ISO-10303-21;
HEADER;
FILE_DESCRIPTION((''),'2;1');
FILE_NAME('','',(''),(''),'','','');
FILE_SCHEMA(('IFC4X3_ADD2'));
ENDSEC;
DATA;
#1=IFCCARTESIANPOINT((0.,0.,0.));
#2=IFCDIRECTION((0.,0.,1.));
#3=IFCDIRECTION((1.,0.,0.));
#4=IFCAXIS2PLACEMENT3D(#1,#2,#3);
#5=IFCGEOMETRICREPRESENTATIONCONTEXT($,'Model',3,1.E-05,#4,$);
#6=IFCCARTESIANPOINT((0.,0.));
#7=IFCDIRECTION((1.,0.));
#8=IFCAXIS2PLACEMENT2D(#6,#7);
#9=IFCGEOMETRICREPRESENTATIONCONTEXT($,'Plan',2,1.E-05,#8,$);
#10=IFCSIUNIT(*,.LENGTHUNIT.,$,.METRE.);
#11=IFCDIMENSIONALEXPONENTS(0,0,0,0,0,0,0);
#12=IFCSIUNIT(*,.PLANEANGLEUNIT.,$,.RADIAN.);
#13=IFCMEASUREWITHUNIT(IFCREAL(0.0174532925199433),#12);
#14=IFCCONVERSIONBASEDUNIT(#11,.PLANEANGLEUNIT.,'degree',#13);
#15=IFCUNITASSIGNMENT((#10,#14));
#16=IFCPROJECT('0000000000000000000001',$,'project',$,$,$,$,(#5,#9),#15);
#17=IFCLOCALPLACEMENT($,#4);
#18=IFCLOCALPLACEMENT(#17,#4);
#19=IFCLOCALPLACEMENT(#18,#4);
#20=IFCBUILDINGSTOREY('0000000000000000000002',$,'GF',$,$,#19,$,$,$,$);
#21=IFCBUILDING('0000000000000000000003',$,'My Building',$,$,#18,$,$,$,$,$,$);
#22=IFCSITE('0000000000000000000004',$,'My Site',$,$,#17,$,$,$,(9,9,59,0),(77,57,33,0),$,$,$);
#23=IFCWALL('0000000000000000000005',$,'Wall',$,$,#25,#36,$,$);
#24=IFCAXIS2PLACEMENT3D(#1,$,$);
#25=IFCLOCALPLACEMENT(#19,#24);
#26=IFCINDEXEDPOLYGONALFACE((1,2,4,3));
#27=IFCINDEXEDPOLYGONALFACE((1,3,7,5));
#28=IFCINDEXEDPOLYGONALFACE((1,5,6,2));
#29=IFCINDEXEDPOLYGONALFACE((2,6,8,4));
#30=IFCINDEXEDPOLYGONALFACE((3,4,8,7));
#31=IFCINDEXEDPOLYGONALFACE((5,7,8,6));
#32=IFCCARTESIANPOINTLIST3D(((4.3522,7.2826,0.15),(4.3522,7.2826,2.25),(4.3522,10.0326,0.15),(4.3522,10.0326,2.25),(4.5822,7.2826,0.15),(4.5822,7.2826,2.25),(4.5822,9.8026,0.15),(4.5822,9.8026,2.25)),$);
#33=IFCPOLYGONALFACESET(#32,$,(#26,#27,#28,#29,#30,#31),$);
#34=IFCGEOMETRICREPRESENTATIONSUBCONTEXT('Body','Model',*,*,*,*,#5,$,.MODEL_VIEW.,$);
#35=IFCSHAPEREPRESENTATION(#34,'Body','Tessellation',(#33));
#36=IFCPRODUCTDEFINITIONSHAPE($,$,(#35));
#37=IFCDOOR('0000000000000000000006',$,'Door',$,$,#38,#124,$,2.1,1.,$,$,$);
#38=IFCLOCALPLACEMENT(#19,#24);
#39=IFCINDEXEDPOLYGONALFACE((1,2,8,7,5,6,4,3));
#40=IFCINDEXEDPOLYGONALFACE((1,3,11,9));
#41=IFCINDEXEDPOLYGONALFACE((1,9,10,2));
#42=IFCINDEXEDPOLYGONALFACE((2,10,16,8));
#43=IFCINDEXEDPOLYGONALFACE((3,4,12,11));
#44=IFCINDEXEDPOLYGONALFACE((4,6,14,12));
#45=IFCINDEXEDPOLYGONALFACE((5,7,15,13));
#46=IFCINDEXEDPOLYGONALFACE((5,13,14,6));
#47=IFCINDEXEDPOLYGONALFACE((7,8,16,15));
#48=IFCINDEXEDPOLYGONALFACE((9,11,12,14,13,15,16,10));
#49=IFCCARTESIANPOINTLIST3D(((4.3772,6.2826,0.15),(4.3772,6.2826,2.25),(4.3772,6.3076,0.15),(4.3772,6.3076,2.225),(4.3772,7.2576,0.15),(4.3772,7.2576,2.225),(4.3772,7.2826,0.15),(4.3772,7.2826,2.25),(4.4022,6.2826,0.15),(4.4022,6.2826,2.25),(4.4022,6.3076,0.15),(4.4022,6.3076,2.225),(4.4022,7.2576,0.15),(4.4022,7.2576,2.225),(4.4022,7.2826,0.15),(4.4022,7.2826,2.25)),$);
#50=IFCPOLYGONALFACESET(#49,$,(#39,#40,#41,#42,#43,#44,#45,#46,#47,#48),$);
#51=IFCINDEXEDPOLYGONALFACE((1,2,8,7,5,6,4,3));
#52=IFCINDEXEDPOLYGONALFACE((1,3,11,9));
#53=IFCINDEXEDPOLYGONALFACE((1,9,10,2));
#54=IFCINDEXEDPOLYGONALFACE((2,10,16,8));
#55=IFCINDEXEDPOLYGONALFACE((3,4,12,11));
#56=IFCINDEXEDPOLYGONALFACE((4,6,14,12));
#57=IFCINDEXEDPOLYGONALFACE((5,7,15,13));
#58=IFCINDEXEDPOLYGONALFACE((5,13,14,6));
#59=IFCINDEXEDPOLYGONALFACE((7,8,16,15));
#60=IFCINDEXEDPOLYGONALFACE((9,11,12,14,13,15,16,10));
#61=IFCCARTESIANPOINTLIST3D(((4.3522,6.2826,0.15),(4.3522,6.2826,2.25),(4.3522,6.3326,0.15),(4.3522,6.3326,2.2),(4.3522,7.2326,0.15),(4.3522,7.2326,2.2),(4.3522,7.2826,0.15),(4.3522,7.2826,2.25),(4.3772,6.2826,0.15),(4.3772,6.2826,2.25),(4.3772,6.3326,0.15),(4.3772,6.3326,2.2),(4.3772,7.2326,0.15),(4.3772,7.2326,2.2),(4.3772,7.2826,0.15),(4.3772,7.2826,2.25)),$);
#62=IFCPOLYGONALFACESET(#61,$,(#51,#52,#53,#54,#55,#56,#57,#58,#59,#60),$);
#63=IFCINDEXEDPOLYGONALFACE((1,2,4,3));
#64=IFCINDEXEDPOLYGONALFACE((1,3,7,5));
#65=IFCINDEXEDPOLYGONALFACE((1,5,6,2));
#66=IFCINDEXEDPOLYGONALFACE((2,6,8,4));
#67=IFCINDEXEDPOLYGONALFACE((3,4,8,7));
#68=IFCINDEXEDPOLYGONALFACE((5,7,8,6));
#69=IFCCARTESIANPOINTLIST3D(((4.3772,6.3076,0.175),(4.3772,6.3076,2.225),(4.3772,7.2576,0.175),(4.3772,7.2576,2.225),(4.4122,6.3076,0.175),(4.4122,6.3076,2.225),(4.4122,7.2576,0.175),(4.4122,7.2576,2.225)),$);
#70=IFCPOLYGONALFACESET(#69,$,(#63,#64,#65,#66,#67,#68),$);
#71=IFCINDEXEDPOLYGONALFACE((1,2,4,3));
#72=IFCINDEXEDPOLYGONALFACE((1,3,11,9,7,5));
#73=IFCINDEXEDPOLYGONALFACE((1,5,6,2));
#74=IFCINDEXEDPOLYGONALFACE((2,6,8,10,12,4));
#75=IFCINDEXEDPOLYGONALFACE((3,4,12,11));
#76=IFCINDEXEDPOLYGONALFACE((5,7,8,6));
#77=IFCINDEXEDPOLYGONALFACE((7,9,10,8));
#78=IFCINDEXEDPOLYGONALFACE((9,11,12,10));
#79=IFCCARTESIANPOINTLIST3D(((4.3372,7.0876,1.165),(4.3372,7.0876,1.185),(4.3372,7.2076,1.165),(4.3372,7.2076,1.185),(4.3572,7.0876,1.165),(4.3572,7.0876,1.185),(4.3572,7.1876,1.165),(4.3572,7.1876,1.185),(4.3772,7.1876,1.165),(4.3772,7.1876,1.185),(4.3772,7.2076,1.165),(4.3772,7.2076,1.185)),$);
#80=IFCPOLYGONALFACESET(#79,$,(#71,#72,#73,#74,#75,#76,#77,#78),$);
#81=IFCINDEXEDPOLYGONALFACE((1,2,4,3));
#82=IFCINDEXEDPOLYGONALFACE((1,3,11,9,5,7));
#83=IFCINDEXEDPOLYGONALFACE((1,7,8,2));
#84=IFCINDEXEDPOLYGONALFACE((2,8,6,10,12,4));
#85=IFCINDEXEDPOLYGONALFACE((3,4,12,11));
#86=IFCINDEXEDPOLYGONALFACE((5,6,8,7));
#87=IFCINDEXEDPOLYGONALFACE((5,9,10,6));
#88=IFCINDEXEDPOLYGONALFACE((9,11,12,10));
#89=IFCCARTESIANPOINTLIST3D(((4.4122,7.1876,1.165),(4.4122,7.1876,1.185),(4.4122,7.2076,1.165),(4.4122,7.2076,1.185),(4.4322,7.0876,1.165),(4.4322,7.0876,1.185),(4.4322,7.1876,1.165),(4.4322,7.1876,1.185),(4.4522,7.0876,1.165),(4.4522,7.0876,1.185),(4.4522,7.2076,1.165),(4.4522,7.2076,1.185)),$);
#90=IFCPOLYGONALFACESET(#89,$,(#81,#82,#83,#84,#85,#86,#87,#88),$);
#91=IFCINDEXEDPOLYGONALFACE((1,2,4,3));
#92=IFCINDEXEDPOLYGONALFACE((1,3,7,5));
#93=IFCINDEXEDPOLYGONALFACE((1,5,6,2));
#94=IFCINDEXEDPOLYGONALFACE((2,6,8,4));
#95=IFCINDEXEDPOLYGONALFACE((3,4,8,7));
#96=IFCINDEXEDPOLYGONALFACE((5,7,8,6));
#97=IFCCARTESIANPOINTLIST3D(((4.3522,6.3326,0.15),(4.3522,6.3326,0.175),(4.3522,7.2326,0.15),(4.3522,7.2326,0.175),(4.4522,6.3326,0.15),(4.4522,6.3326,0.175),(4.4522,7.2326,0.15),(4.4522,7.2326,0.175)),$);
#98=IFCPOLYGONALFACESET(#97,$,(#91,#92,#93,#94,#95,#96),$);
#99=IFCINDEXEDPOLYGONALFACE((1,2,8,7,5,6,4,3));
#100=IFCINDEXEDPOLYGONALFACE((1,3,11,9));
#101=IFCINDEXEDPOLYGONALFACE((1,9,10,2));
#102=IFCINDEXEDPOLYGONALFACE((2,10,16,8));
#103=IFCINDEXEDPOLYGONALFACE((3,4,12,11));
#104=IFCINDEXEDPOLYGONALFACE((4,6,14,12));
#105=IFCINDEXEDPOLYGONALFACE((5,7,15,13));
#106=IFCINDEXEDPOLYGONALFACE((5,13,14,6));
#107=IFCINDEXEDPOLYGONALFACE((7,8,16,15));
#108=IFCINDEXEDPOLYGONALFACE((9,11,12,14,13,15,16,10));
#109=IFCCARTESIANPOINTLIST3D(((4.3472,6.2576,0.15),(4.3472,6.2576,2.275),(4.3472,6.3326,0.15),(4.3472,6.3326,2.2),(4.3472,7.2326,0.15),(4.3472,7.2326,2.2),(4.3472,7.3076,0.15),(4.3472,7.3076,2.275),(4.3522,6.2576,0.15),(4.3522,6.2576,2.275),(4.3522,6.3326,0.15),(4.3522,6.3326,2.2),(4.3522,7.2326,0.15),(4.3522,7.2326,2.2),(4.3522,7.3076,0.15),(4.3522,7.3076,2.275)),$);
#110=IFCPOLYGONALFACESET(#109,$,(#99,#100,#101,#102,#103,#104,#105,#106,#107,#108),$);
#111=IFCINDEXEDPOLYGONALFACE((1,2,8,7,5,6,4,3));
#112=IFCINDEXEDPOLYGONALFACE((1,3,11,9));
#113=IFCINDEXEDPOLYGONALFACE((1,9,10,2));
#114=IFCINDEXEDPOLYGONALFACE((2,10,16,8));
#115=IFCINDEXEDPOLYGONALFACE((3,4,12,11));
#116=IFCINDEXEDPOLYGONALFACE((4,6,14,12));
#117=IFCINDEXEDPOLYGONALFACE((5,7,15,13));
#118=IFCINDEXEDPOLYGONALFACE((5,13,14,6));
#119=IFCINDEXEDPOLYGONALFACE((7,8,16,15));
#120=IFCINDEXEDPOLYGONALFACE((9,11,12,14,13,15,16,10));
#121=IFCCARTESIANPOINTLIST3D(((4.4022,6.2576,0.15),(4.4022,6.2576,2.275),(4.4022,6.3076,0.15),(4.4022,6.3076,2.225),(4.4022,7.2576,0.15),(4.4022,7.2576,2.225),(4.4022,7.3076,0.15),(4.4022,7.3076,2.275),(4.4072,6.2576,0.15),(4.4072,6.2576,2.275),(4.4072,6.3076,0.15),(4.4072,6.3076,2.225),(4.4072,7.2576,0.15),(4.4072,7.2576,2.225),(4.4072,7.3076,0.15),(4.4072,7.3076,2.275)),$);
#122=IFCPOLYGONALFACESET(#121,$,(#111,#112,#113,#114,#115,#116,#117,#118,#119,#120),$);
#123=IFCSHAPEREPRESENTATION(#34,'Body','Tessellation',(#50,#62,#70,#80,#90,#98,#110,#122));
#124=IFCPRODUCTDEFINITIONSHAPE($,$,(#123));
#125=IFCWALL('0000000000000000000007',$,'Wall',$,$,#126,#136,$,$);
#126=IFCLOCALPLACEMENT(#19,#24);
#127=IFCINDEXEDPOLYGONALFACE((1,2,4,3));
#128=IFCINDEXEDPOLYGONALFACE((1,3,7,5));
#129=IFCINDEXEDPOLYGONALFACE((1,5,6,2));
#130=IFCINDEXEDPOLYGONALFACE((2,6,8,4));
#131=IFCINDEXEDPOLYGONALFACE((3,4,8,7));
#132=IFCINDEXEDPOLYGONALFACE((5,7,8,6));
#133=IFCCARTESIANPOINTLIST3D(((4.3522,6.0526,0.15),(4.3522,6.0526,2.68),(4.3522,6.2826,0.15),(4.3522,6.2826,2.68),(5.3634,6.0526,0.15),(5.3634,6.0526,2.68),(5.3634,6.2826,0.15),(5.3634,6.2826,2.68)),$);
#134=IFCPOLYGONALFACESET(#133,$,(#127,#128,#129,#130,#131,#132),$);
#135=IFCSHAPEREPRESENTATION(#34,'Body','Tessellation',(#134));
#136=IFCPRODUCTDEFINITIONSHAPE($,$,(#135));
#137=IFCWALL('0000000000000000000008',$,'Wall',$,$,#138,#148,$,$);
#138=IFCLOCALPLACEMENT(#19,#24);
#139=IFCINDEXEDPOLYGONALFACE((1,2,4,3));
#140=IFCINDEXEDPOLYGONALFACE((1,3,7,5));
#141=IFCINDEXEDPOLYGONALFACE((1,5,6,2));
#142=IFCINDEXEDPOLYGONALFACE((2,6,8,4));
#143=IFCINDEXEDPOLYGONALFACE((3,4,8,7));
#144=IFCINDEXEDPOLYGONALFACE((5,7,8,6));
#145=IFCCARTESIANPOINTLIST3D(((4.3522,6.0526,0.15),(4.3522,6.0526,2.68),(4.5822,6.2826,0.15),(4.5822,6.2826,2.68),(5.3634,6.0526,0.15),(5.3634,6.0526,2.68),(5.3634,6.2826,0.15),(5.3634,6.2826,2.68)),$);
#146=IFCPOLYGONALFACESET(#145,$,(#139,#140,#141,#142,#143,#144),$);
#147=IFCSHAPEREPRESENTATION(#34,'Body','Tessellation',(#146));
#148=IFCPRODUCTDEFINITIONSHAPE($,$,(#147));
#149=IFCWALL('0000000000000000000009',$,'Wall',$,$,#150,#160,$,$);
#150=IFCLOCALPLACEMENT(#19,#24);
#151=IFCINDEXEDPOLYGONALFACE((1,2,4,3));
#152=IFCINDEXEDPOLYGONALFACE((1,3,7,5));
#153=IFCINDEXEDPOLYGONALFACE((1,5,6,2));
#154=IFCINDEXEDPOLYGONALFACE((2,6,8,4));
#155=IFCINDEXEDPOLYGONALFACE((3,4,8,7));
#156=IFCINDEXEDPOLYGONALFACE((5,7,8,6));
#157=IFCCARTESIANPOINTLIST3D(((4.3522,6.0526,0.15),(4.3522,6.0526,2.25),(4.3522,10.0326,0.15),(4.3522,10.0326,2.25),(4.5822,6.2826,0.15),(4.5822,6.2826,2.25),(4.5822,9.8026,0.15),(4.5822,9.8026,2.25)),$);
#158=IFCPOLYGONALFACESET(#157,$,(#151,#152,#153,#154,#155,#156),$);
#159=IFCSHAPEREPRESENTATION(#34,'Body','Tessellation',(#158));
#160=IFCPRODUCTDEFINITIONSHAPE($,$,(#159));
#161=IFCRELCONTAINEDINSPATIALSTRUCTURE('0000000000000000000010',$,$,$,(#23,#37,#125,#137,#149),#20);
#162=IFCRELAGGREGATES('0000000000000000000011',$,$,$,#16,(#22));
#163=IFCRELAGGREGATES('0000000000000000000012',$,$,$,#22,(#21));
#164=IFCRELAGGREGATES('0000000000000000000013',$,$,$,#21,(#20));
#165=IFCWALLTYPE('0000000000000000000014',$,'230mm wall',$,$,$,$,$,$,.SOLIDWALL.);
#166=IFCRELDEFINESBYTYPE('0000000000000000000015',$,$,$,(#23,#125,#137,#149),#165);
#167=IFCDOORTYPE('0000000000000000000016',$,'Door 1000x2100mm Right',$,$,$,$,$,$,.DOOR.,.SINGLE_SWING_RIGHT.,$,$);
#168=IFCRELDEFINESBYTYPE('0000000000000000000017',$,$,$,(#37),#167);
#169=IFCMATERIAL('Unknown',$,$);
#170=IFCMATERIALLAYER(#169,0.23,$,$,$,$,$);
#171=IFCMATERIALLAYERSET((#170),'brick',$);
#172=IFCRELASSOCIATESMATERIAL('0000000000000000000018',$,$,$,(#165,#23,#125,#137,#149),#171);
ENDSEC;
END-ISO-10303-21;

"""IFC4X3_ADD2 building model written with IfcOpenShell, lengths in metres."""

from ifc_helpers import new_model, entity, si_unit, converted_unit, frame, origin_with_axes, origin_2d_with_axis, place, context, subcontext, project, spatial, line, indexed_curve, outline, extrude, shape, source, transform, mapped, material, layer, layer_set, layer_usage, type_object, type_shapes, element, fill, save


model = new_model("IFC4X3_ADD2")

# Units and contexts
model_context = context("Model", 3, precision=1e-05, world=origin_with_axes())
plan_context = context("Plan", 2, precision=1e-05, world=origin_2d_with_axis())
body_context_1 = subcontext(model_context, "Body", "Model", "MODEL_VIEW")
body_context_2 = subcontext(plan_context, "Body", "Plan", "PLAN_VIEW")
ifc_project = project(units=[si_unit("LENGTHUNIT", "METRE"), converted_unit("PLANEANGLEUNIT", "degree", entity("IfcReal", 0.0174532925199433), si_unit("PLANEANGLEUNIT", "RADIAN"), dimensions=[0, 0, 0, 0, 0, 0, 0])], contexts=[model_context, plan_context])

# Site, building, storey
site_placement = place(None, origin_with_axes())
site = spatial("IfcSite", under=ifc_project, at=site_placement, Name="My Site", RefLatitude=(9, 9, 59, 0), RefLongitude=(77, 57, 33, 0))
building_placement = place(site_placement, origin_with_axes())
building = spatial("IfcBuilding", under=site, at=building_placement, Name="My Building")
storey_placement = place(building_placement, origin_with_axes())
storey = spatial("IfcBuildingStorey", under=building, at=storey_placement, Name="GF")

# Shared definitions
ifc_material_1 = material(Name="Unknown")
ifc_layer_1 = layer(ifc_material_1, 0.23)
ifc_layer_set_1 = layer_set([ifc_layer_1], Name="brick")
wall_type_1 = type_object("IfcWallType", Name="230mm wall", PredefinedType="SOLIDWALL", material=ifc_layer_set_1)

# Wall, opening, door
ifc_layer_usage_1 = layer_usage(ifc_layer_set_1, "AXIS2", "POSITIVE", 0.0)
wall_1_placement = place(storey_placement, frame((4.5822, 6.2826, 0.15), z_axis=(0.0, 0.0, 1.0), x_axis=(0.0, 1.0, 0.0)))
wall_1 = element("IfcWall", 1, at=wall_1_placement, inside=storey, type_object=wall_type_1, material=ifc_layer_usage_1, Name="Wall", context=body_context_1, shape_type="SweptSolid", body=[
    extrude(outline(indexed_curve([(0.0, 0.0), (0.0, 0.23), (3.75, 0.23), (3.52, 0.0)], segments=[line(1, 2, 3, 4, 1)])), origin_with_axes(), (0.0, 0.0, 1.0), 2.1),
])
shared_shape_1 = source(origin_with_axes(), body_context_1, "Body", "SweptSolid", [
    extrude(outline(indexed_curve([(0.0, 0.0), (1.0, 0.0), (1.0, 2.1), (0.0, 2.1)], segments=[line(1, 2, 3, 4, 1)])), frame((0.0, -0.6, 0.0), z_axis=(0.0, -1.0, 0.0), x_axis=(1.0, 0.0, 0.0)), (0.0, 0.0, -1.0), 1.2),
])
opening_1_placement = place(wall_1_placement, frame((1.0, 0.23, 0.0), z_axis=(0.0, 0.0, 1.0), x_axis=(-1.0, 0.0, 0.0)))
opening_1 = element("IfcOpeningElement", 2, at=opening_1_placement, cuts=wall_1, PredefinedType="OPENING", context=body_context_1, shape_type="MappedRepresentation", body=[
    mapped(shared_shape_1, transform((0.0, 0.0, 0.0), x_axis=(1.0, 0.0, 0.0), y_axis=(0.0, 1.0, 0.0), z_axis=(0.0, 0.0, 1.0), scale=1.0)),
])
door_type_1 = type_object("IfcDoorType", Name="Door 1000x2100mm Right", OperationType="SINGLE_SWING_RIGHT", PredefinedType="DOOR")
shared_shape_2 = source(origin_with_axes(), body_context_1, "Body", "SweptSolid", [
    extrude(outline(indexed_curve([(0.0, 0.0), (0.0, 2.1), (1.0, 2.1), (1.0, 0.0), (0.975, 0.0), (0.975, 2.075), (0.025, 2.075), (0.025, 0.0)], segments=[line(1, 2, 3, 4, 5, 6, 7, 8, 1)])), frame((0.0, 0.025, 0.0), z_axis=(0.0, -1.0, 0.0), x_axis=(1.0, 0.0, 0.0)), (0.0, 0.0, -1.0), 0.025),
    extrude(outline(indexed_curve([(0.0, 0.0), (0.0, 2.1), (1.0, 2.1), (1.0, 0.0), (0.95, 0.0), (0.95, 2.05), (0.05, 2.05), (0.05, 0.0)], segments=[line(1, 2, 3, 4, 5, 6, 7, 8, 1)])), frame((0.0, 0.0, 0.0), z_axis=(0.0, -1.0, 0.0), x_axis=(1.0, 0.0, 0.0)), (0.0, 0.0, -1.0), 0.025),
    extrude(outline(indexed_curve([(0.0, 0.0), (0.95, 0.0), (0.95, 0.035), (0.0, 0.035)], segments=[line(1, 2, 3, 4, 1)])), frame((0.025, 0.025, 0.025), z_axis=(0.0, 0.0, 1.0), x_axis=(1.0, 0.0, 0.0)), (0.0, 0.0, 1.0), 2.05),
    extrude(outline(indexed_curve([(0.0, 0.0), (0.0, -0.04), (0.12, -0.04), (0.12, -0.02), (0.02, -0.02), (0.02, 0.0)], segments=[line(1, 2, 3, 4, 5, 6, 1)])), frame((0.075, 0.025, 1.015), z_axis=(0.0, 0.0, 1.0), x_axis=(1.0, 0.0, 0.0)), (0.0, 0.0, 1.0), 0.02),
    extrude(outline(indexed_curve([(0.0, 0.0), (0.0, 0.04), (0.12, 0.04), (0.12, 0.02), (0.02, 0.02), (0.02, 0.0)], segments=[line(1, 2, 3, 4, 5, 6, 1)])), frame((0.075, 0.06, 1.015), z_axis=(0.0, 0.0, 1.0), x_axis=(1.0, 0.0, 0.0)), (0.0, 0.0, 1.0), 0.02),
    extrude(outline(indexed_curve([(0.0, 0.0), (0.9, 0.0), (0.9, 0.1), (0.0, 0.1)], segments=[line(1, 2, 3, 4, 1)])), frame((0.05, 0.0, 0.0), z_axis=(0.0, 0.0, 1.0), x_axis=(1.0, 0.0, 0.0)), (0.0, 0.0, 1.0), 0.025),
    extrude(outline(indexed_curve([(0.0, 0.0), (0.0, 2.125), (1.05, 2.125), (1.05, 0.0), (0.975, 0.0), (0.975, 2.05), (0.075, 2.05), (0.075, 0.0)], segments=[line(1, 2, 3, 4, 5, 6, 7, 8, 1)])), frame((-0.025, -0.005, 0.0), z_axis=(0.0, -1.0, 0.0), x_axis=(1.0, 0.0, 0.0)), (0.0, 0.0, -1.0), 0.005),
    extrude(outline(indexed_curve([(0.0, 0.0), (0.0, 2.125), (1.05, 2.125), (1.05, 0.0), (1.0, 0.0), (1.0, 2.075), (0.05, 2.075), (0.05, 0.0)], segments=[line(1, 2, 3, 4, 5, 6, 7, 8, 1)])), frame((-0.025, 0.05, 0.0), z_axis=(0.0, -1.0, 0.0), x_axis=(1.0, 0.0, 0.0)), (0.0, 0.0, -1.0), 0.005),
])
shared_shape_3 = source(origin_with_axes(), body_context_2, "Body", "Curve2D", [
    entity("IfcIndexedPolyCurve", entity("IfcCartesianPointList2D", [[0.0, 0.0], [0.0, 0.05], [0.025, 0.05], [0.025, 0.025], [0.05, 0.025], [0.05, 0.0]]), [entity("IfcLineIndex", [1, 2, 3, 4, 5, 6, 1])]),
    entity("IfcIndexedPolyCurve", entity("IfcCartesianPointList2D", [[1.0, 0.0], [1.0, 0.05], [0.975, 0.05], [0.975, 0.025], [0.95, 0.025], [0.95, 0.0]]), [entity("IfcLineIndex", [1, 2, 3, 4, 5, 6, 1])]),
    entity("IfcTrimmedCurve", entity("IfcEllipse", entity("IfcAxis2Placement2D", entity("IfcCartesianPoint", [0.94, 0.05]), entity("IfcDirection", [1.0, 0.0])), 0.915, 0.95), [entity("IfcCartesianPoint", [0.94, 1.0])], [entity("IfcCartesianPoint", [0.025, 0.05])], True, "CARTESIAN"),
    entity("IfcIndexedPolyCurve", entity("IfcCartesianPointList2D", [[0.975, 0.05], [0.94, 0.05], [0.94, 1.0], [0.975, 1.0]]), [entity("IfcLineIndex", [1, 2, 3, 4, 1])]),
])
type_shapes(door_type_1, [shared_shape_2, shared_shape_3])
door_1_placement = place(opening_1_placement, frame((0.0, 0.0, 0.0), z_axis=(0.0, 0.0, 1.0), x_axis=(1.0, 0.0, 0.0)))
door_1 = element("IfcDoor", 3, at=door_1_placement, inside=storey, type_object=door_type_1, Name="Door", OverallHeight=2.1, OverallWidth=1.0, shapes=[
    shape(body_context_1, "Body", "MappedRepresentation", [mapped(shared_shape_2, transform((0.0, 0.0, 0.0), x_axis=(1.0, 0.0, 0.0), y_axis=(0.0, 1.0, 0.0), z_axis=(0.0, 0.0, 1.0), scale=1.0))]),
    shape(body_context_2, "Body", "MappedRepresentation", [mapped(shared_shape_3, transform((0.0, 0.0, 0.0), x_axis=(1.0, 0.0, 0.0), y_axis=(0.0, 1.0, 0.0), z_axis=(0.0, 0.0, 1.0), scale=1.0))]),
])
fill(opening_1, door_1)

# Walls
ifc_layer_usage_2 = layer_usage(ifc_layer_set_1, "AXIS2", "POSITIVE", 0.0)
wall_2_placement = place(storey_placement, frame((5.3634, 6.2826, 0.15), z_axis=(0.0, 0.0, 1.0), x_axis=(-1.0, 0.0, 0.0)))
element("IfcWall", 4, at=wall_2_placement, inside=storey, type_object=wall_type_1, material=ifc_layer_usage_2, Name="Wall", context=body_context_1, shape_type="SweptSolid", body=[
    extrude(outline(indexed_curve([(0.0, 0.0), (0.0, 0.23), (1.0112, 0.23), (1.0112, 0.0)], segments=[line(1, 2, 3, 4, 1)])), origin_with_axes(), (0.0, 0.0, 1.0), 2.53),
])
ifc_layer_usage_3 = layer_usage(ifc_layer_set_1, "AXIS2", "POSITIVE", 0.0)
wall_3_placement = place(storey_placement, frame((5.3634, 6.2826, 0.15), z_axis=(0.0, 0.0, 1.0), x_axis=(-1.0, 0.0, 0.0)))
element("IfcWall", 5, at=wall_3_placement, inside=storey, type_object=wall_type_1, material=ifc_layer_usage_3, Name="Wall", context=body_context_1, shape_type="SweptSolid", body=[
    extrude(outline(indexed_curve([(0.0, 0.0), (0.0, 0.23), (1.0112, 0.23), (0.7812, 0.0)], segments=[line(1, 2, 3, 4, 1)])), origin_with_axes(), (0.0, 0.0, 1.0), 2.53),
])
ifc_layer_usage_4 = layer_usage(ifc_layer_set_1, "AXIS2", "POSITIVE", 0.0)
wall_4_placement = place(storey_placement, frame((4.5822, 6.2826, 0.15), z_axis=(0.0, 0.0, 1.0), x_axis=(0.0, 1.0, 0.0)))
element("IfcWall", 6, at=wall_4_placement, inside=storey, type_object=wall_type_1, material=ifc_layer_usage_4, Name="Wall", context=body_context_1, shape_type="SweptSolid", body=[
    extrude(outline(indexed_curve([(0.0, 0.0), (-0.23, 0.23), (3.75, 0.23), (3.52, 0.0)], segments=[line(1, 2, 3, 4, 1)])), origin_with_axes(), (0.0, 0.0, 1.0), 2.1),
])

save(model, "model.ifc")
